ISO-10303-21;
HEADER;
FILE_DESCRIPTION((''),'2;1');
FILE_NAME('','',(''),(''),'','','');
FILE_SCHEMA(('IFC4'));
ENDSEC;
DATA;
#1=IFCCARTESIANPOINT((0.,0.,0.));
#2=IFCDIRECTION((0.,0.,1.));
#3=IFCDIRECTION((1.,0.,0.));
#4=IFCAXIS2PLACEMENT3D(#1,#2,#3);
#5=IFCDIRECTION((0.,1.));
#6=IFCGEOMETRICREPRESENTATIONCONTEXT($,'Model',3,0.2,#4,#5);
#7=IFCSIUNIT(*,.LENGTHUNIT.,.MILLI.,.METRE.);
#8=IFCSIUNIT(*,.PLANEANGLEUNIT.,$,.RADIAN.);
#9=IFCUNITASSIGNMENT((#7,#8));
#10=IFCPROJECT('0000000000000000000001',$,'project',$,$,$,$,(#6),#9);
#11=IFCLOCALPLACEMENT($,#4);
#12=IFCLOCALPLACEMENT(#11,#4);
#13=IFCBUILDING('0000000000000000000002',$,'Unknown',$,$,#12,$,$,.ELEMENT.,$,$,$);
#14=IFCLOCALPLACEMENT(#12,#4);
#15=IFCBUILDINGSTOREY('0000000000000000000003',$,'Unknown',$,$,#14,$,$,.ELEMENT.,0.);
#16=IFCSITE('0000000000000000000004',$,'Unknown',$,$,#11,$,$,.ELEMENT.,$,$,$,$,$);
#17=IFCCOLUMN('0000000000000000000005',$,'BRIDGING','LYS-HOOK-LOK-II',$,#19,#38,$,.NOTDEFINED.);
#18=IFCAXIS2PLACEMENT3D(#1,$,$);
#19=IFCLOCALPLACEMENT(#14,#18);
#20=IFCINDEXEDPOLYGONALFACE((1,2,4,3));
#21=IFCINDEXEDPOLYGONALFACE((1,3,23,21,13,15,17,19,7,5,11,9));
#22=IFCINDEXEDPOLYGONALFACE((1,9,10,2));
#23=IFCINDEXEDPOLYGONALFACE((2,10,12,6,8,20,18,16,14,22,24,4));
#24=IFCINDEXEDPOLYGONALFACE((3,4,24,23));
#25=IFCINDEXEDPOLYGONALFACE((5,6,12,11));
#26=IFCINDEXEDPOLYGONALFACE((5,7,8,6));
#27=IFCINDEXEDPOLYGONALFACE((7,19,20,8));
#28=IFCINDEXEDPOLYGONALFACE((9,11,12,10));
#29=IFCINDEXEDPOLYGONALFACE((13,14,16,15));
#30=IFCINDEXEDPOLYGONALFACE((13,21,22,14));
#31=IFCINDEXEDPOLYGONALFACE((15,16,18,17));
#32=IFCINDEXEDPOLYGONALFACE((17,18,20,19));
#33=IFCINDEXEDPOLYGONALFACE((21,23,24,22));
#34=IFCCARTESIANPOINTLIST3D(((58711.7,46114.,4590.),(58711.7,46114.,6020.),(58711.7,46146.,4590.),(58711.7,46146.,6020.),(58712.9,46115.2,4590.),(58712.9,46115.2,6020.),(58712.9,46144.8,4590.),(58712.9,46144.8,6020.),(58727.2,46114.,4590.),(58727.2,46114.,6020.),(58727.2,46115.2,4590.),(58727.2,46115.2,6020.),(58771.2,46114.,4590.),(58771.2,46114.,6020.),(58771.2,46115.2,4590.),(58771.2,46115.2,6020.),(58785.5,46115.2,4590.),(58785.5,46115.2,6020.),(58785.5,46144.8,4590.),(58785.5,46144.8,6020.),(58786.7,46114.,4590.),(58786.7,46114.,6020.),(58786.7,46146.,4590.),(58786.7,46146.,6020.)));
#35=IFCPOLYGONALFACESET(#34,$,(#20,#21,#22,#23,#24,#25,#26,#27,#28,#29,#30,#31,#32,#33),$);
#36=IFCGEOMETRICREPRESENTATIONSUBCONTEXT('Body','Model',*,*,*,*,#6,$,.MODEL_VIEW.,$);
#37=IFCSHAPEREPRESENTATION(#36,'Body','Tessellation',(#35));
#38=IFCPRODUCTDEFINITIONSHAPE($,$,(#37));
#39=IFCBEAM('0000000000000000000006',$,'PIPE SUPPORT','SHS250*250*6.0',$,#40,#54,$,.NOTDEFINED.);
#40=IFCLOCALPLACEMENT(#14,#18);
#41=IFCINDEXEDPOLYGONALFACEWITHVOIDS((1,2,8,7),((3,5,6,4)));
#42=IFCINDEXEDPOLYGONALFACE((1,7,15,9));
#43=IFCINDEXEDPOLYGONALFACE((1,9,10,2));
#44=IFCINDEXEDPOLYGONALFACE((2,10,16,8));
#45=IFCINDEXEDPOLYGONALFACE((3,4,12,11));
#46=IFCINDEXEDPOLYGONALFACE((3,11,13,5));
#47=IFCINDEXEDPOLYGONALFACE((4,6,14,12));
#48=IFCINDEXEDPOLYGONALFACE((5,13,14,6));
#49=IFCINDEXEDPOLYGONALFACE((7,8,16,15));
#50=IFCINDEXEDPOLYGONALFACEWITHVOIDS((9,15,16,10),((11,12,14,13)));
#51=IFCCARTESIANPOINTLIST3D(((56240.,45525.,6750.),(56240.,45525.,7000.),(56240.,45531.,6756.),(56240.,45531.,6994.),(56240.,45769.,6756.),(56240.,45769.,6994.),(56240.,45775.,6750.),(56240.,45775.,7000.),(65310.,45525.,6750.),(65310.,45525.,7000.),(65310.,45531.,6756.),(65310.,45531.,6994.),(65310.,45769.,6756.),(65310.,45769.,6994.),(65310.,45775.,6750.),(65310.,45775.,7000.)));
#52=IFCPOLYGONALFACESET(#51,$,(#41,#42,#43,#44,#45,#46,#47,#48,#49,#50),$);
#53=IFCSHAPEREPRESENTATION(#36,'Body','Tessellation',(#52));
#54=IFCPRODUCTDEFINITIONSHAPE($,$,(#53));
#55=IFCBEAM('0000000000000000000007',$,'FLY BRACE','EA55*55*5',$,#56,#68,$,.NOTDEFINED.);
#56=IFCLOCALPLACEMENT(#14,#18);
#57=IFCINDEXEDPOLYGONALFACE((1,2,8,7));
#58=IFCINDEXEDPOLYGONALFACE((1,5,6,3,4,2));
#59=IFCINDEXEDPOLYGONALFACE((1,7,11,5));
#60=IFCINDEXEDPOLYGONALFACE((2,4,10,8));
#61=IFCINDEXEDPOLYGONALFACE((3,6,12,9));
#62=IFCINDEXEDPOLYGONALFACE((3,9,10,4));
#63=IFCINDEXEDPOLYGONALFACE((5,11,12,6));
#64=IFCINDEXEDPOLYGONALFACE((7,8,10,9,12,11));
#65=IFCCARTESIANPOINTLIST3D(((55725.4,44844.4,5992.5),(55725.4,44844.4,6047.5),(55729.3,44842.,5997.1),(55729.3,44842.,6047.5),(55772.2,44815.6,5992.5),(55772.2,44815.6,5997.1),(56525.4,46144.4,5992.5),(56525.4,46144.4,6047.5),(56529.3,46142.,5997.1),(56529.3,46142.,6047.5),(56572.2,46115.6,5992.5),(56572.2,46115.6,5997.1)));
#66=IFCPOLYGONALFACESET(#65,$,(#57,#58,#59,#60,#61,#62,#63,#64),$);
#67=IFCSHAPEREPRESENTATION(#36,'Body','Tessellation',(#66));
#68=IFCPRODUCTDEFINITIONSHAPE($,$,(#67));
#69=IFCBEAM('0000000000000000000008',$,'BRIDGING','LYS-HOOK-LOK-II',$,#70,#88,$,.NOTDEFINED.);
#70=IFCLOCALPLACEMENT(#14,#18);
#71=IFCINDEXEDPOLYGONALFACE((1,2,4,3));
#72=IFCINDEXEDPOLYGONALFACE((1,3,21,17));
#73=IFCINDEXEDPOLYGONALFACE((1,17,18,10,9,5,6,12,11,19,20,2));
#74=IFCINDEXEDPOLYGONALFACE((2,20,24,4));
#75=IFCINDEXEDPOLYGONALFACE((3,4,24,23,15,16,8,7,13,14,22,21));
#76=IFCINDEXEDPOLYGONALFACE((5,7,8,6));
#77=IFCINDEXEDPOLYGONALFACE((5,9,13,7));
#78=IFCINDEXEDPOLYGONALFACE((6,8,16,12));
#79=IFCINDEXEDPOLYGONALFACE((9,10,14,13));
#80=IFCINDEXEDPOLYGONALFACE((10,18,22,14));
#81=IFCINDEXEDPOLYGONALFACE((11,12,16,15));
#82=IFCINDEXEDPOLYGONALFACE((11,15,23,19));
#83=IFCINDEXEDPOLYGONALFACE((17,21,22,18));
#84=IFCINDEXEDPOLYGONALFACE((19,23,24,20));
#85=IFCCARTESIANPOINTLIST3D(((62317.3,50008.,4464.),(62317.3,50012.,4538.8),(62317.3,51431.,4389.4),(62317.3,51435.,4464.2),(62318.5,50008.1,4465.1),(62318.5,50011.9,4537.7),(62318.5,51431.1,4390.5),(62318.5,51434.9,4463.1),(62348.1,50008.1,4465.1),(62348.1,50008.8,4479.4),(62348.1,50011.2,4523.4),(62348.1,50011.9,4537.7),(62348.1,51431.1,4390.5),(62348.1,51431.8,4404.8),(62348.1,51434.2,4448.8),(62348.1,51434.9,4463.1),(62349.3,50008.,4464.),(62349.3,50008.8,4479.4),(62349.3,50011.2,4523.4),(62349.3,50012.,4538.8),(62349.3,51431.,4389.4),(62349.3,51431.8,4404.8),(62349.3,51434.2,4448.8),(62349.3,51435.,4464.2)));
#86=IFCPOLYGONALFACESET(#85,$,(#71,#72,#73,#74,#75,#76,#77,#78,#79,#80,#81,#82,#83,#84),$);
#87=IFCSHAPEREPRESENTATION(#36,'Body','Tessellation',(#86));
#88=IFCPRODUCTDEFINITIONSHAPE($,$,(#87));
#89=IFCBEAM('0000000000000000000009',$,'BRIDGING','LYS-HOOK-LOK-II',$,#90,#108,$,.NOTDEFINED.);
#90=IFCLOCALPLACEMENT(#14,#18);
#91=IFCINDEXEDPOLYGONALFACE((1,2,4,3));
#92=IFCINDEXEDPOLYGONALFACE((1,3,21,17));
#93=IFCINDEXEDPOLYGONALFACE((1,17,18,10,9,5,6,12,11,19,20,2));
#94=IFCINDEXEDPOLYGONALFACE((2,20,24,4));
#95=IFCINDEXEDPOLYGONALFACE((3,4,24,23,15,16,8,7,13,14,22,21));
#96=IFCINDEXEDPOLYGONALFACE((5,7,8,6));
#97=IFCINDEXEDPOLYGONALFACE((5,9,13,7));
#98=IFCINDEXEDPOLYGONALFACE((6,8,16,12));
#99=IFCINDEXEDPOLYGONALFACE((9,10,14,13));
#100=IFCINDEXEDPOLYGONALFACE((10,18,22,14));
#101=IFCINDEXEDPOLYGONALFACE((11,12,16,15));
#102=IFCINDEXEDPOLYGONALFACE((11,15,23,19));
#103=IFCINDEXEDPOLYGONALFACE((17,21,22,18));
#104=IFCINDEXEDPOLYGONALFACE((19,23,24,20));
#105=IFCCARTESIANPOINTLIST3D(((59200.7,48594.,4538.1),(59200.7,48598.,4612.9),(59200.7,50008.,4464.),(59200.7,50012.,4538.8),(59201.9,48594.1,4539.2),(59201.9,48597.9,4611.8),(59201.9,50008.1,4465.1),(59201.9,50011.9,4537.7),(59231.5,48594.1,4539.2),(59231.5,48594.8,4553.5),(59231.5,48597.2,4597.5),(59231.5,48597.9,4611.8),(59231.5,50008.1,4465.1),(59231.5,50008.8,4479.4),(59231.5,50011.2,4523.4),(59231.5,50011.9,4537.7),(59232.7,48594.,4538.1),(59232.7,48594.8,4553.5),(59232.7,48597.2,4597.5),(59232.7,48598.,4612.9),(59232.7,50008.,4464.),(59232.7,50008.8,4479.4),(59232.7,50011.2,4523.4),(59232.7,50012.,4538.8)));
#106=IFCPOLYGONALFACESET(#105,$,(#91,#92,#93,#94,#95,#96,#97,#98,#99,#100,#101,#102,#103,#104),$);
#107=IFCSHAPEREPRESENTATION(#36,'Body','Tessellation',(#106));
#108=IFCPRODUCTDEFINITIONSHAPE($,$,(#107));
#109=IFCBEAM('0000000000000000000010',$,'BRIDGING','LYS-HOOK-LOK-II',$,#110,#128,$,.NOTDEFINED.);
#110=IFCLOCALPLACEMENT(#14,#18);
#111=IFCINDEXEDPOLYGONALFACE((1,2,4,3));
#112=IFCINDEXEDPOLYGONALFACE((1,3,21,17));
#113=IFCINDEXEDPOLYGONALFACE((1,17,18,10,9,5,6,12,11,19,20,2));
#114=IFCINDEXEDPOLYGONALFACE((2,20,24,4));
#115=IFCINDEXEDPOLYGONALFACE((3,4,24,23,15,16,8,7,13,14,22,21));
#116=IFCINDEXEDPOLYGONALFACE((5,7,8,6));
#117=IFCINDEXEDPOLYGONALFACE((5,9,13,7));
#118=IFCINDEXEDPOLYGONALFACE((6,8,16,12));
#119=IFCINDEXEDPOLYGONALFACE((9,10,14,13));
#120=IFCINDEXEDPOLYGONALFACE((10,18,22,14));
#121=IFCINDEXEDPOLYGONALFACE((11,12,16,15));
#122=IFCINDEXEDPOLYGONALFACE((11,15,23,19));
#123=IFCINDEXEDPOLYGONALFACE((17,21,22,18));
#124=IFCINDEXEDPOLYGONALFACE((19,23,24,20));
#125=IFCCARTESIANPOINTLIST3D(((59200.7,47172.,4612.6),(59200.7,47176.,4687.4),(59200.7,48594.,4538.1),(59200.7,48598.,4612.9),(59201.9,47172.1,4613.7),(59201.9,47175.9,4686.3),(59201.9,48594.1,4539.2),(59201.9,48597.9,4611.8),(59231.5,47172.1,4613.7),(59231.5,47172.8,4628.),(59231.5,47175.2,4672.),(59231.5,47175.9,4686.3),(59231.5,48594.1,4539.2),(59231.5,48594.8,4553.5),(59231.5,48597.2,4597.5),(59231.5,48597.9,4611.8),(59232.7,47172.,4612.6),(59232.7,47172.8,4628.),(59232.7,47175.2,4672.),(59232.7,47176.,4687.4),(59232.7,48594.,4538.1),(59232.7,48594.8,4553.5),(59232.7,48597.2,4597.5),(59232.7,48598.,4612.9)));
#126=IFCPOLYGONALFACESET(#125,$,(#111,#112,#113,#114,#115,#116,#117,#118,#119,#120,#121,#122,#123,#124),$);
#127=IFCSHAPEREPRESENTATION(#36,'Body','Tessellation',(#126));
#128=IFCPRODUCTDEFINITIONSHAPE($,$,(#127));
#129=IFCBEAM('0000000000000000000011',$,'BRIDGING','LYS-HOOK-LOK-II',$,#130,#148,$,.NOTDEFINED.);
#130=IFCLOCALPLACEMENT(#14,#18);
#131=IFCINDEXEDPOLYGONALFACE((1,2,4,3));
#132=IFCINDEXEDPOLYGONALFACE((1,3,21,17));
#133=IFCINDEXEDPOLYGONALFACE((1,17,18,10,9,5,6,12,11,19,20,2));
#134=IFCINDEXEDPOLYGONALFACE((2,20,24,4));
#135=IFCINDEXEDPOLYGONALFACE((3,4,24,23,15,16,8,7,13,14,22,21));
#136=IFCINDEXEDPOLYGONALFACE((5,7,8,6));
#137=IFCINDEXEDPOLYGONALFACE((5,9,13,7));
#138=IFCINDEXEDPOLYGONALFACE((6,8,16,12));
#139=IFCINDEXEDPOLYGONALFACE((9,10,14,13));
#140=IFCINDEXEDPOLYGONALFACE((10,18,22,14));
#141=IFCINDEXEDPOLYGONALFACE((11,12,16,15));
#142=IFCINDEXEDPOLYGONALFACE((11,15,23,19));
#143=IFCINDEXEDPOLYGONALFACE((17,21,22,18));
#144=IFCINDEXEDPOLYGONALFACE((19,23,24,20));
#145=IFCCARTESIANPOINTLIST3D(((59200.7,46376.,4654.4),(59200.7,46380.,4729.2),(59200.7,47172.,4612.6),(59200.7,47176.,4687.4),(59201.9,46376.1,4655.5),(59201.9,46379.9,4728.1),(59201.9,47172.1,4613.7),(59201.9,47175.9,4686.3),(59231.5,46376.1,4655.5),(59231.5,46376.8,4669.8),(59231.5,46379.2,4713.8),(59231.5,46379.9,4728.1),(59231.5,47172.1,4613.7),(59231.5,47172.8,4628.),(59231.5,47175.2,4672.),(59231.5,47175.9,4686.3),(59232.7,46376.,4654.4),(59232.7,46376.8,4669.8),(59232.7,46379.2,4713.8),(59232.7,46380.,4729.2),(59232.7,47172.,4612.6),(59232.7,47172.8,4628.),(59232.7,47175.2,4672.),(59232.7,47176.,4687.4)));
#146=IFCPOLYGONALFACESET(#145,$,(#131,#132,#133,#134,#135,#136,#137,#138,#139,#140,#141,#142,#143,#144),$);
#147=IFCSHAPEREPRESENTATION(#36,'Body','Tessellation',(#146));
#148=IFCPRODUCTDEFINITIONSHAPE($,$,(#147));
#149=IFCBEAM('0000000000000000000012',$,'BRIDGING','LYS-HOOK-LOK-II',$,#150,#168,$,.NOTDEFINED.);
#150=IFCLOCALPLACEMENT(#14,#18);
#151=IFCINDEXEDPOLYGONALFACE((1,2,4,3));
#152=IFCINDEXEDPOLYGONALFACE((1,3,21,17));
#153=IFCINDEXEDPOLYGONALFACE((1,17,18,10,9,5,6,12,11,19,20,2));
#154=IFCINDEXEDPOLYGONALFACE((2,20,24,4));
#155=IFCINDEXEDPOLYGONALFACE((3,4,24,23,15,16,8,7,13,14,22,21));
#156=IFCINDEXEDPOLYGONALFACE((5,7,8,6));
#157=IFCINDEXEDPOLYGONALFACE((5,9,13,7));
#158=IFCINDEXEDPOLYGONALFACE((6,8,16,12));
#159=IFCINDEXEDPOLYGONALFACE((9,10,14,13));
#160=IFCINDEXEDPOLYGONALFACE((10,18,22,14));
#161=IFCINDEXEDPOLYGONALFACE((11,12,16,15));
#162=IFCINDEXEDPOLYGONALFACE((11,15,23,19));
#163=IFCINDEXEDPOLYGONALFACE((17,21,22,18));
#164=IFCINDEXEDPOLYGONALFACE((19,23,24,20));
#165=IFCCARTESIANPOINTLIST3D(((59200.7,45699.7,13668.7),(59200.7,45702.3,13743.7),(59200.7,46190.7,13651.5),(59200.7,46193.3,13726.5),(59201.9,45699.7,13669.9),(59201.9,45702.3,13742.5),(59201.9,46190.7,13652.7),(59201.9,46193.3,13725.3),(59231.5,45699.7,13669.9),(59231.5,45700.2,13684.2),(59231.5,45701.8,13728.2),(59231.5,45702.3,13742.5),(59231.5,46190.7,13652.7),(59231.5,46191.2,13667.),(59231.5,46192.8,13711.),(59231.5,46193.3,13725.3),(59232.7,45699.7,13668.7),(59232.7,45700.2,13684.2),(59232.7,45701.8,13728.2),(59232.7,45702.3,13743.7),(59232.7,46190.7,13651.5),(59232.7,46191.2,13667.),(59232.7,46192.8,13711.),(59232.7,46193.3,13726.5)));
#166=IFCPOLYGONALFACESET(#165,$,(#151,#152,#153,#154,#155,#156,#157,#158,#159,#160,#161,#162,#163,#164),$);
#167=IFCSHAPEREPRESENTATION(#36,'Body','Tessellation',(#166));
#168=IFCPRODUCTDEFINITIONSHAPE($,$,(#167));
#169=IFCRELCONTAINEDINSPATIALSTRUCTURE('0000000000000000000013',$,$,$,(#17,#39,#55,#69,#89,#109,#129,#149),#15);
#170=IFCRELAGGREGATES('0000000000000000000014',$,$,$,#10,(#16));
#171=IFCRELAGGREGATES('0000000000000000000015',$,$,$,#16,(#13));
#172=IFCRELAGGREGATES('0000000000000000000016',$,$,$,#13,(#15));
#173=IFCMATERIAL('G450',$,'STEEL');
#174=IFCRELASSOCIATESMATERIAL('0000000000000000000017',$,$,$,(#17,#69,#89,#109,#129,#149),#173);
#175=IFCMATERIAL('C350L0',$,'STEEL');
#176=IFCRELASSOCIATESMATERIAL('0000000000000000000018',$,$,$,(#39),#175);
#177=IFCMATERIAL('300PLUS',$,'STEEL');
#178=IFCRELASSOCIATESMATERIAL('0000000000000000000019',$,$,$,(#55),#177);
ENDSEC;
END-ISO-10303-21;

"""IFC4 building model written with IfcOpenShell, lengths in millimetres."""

from ifc_helpers import new_model, si_unit, direction, frame, origin_with_axes, place, context, subcontext, project, spatial, line, indexed_curve, outline, extrude, material, element, save


model = new_model("IFC4")

# Units and contexts
model_context = context("Model", 3, precision=0.2, world=origin_with_axes(), true_north=direction((0.0, 1.0)))
body_context = subcontext(model_context, "Body", "Model", "MODEL_VIEW")
ifc_project = project(units=[si_unit("LENGTHUNIT", "METRE", prefix="MILLI"), si_unit("PLANEANGLEUNIT", "RADIAN")], contexts=[model_context])

# Site, building, storey
site_placement = place(None, origin_with_axes())
site = spatial("IfcSite", under=ifc_project, at=site_placement, Name="Unknown", CompositionType="ELEMENT")
building_placement = place(site_placement, origin_with_axes())
building = spatial("IfcBuilding", under=site, at=building_placement, Name="Unknown", CompositionType="ELEMENT")
storey_placement = place(building_placement, origin_with_axes())
storey = spatial("IfcBuildingStorey", under=building, at=storey_placement, Name="Unknown", CompositionType="ELEMENT", Elevation=0.0)

# Column
ifc_material_1 = material(Name="G450", Category="STEEL")
for number, where, z_axis, x_axis, name in (
    (1, (58749.2, 46130.0, 4590.0), (0.0, -1.0, 0.0), (0.0, 0.0, 1.0), "BRIDGING"),
):
    element("IfcColumn", number, at=place(storey_placement, frame(where, z_axis=z_axis, x_axis=x_axis)), inside=storey, material=ifc_material_1, Name=name, Description="LYS-HOOK-LOK-II", PredefinedType="NOTDEFINED", context=body_context, shape_type="SolidModel", body=[
        extrude(outline(indexed_curve([(16.0, -37.5), (16.0, -22.0), (14.8, -22.0), (14.8, -36.3), (-14.8, -36.3), (-14.8, 36.3), (14.8, 36.3), (14.8, 22.0), (16.0, 22.0), (16.0, 37.5), (-16.0, 37.5), (-16.0, -37.5)], segments=[line(1, 2, 3, 4, 5, 6, 7, 8, 9, 10, 11, 12, 1)])), frame((0.0, 0.0, 0.0), z_axis=(-1.0, 0.0, 0.0), x_axis=(0.0, 0.0, 1.0)), (0.0, 0.0, -1.0), 1430.0),
    ])

# Beams
ifc_material_2 = material(Name="C350L0", Category="STEEL")
beam_1_placement = place(storey_placement, frame((56240.0, 45650.0, 6875.0), z_axis=(0.0, 0.0, 1.0), x_axis=(1.0, 0.0, 0.0)))
element("IfcBeam", 2, at=beam_1_placement, inside=storey, material=ifc_material_2, Name="PIPE SUPPORT", Description="SHS250*250*6.0", PredefinedType="NOTDEFINED", context=body_context, shape_type="SolidModel", body=[
    extrude(outline(indexed_curve([(-125.0, -125.0), (125.0, -125.0), (125.0, 125.0), (-125.0, 125.0)], segments=[line(1, 2, 3, 4, 1)]), holes=[indexed_curve([(-119.0, -119.0), (-119.0, 119.0), (119.0, 119.0), (119.0, -119.0)], segments=[line(1, 2, 3, 4, 1)])]), frame((0.0, 0.0, 0.0), z_axis=(-1.0, 0.0, 0.0), x_axis=(0.0, 0.0, 1.0)), (0.0, 0.0, -1.0), 9070.0),
])
ifc_material_3 = material(Name="300PLUS", Category="STEEL")
beam_2_placement = place(storey_placement, frame((56548.8, 46130.0, 6020.0), z_axis=(0.0, 0.0, 1.0), x_axis=(-0.524097, -0.851658, 0.0)))
element("IfcBeam", 3, at=beam_2_placement, inside=storey, material=ifc_material_3, Name="FLY BRACE", Description="EA55*55*5", PredefinedType="NOTDEFINED", context=body_context, shape_type="SolidModel", body=[
    extrude(outline(indexed_curve([(-27.5, -27.5), (27.5, -27.5), (27.5, -22.9), (-22.9, -22.9), (-22.9, 27.5), (-27.5, 27.5)], segments=[line(1, 2, 3, 4, 5, 6, 1)])), frame((0.0, 0.0, 0.0), z_axis=(-1.0, 0.0, 0.0), x_axis=(0.0, 0.0, 1.0)), (0.0, 0.0, -1.0), 1526.4),
])
beam_3_placement = place(storey_placement, frame((62333.3, 50010.0, 4501.4), z_axis=(1.0, 0.0, 0.0), x_axis=(0.0, 0.998629, -0.052353)))
element("IfcBeam", 4, at=beam_3_placement, inside=storey, material=ifc_material_1, Name="BRIDGING", Description="LYS-HOOK-LOK-II", PredefinedType="NOTDEFINED", context=body_context, shape_type="SolidModel", body=[
    extrude(outline(indexed_curve([(16.0, -37.5), (16.0, -22.0), (14.8, -22.0), (14.8, -36.3), (-14.8, -36.3), (-14.8, 36.3), (14.8, 36.3), (14.8, 22.0), (16.0, 22.0), (16.0, 37.5), (-16.0, 37.5), (-16.0, -37.5)], segments=[line(1, 2, 3, 4, 5, 6, 7, 8, 9, 10, 11, 12, 1)])), frame((0.0, 0.0, 0.0), z_axis=(-1.0, 0.0, 0.0), x_axis=(0.0, 0.0, 1.0)), (0.0, 0.0, -1.0), 1425.0),
])
beam_4_placement = place(storey_placement, frame((59216.7, 48596.0, 4575.5), z_axis=(1.0, 0.0, 0.0), x_axis=(0.0, 0.99863, -0.052333)))
element("IfcBeam", 5, at=beam_4_placement, inside=storey, material=ifc_material_1, Name="BRIDGING", Description="LYS-HOOK-LOK-II", PredefinedType="NOTDEFINED", context=body_context, shape_type="SolidModel", body=[
    extrude(outline(indexed_curve([(16.0, -37.5), (16.0, -22.0), (14.8, -22.0), (14.8, -36.3), (-14.8, -36.3), (-14.8, 36.3), (14.8, 36.3), (14.8, 22.0), (16.0, 22.0), (16.0, 37.5), (-16.0, 37.5), (-16.0, -37.5)], segments=[line(1, 2, 3, 4, 5, 6, 7, 8, 9, 10, 11, 12, 1)])), frame((0.0, 0.0, 0.0), z_axis=(-1.0, 0.0, 0.0), x_axis=(0.0, 0.0, 1.0)), (0.0, 0.0, -1.0), 1415.9),
])
beam_5_placement = place(storey_placement, frame((59216.7, 47174.0, 4650.0), z_axis=(1.0, 0.0, 0.0), x_axis=(0.0, 0.99863, -0.052319)))
element("IfcBeam", 6, at=beam_5_placement, inside=storey, material=ifc_material_1, Name="BRIDGING", Description="LYS-HOOK-LOK-II", PredefinedType="NOTDEFINED", context=body_context, shape_type="SolidModel", body=[
    extrude(outline(indexed_curve([(16.0, -37.5), (16.0, -22.0), (14.8, -22.0), (14.8, -36.3), (-14.8, -36.3), (-14.8, 36.3), (14.8, 36.3), (14.8, 22.0), (16.0, 22.0), (16.0, 37.5), (-16.0, 37.5), (-16.0, -37.5)], segments=[line(1, 2, 3, 4, 5, 6, 7, 8, 9, 10, 11, 12, 1)])), frame((0.0, 0.0, 0.0), z_axis=(-1.0, 0.0, 0.0), x_axis=(0.0, 0.0, 1.0)), (0.0, 0.0, -1.0), 1424.0),
])
beam_6_placement = place(storey_placement, frame((59216.7, 46378.0, 4691.8), z_axis=(1.0, 0.0, 0.0), x_axis=(0.0, 0.998624, -0.05244)))
element("IfcBeam", 7, at=beam_6_placement, inside=storey, material=ifc_material_1, Name="BRIDGING", Description="LYS-HOOK-LOK-II", PredefinedType="NOTDEFINED", context=body_context, shape_type="SolidModel", body=[
    extrude(outline(indexed_curve([(16.0, -37.5), (16.0, -22.0), (14.8, -22.0), (14.8, -36.3), (-14.8, -36.3), (-14.8, 36.3), (14.8, 36.3), (14.8, 22.0), (16.0, 22.0), (16.0, 37.5), (-16.0, 37.5), (-16.0, -37.5)], segments=[line(1, 2, 3, 4, 5, 6, 7, 8, 9, 10, 11, 12, 1)])), frame((0.0, 0.0, 0.0), z_axis=(-1.0, 0.0, 0.0), x_axis=(0.0, 0.0, 1.0)), (0.0, 0.0, -1.0), 797.1),
])
beam_7_placement = place(storey_placement, frame((59216.7, 45701.0, 13706.2), z_axis=(1.0, 0.0, 0.0), x_axis=(0.0, 0.999387, -0.035009)))
element("IfcBeam", 8, at=beam_7_placement, inside=storey, material=ifc_material_1, Name="BRIDGING", Description="LYS-HOOK-LOK-II", PredefinedType="NOTDEFINED", context=body_context, shape_type="SolidModel", body=[
    extrude(outline(indexed_curve([(16.0, -37.5), (16.0, -22.0), (14.8, -22.0), (14.8, -36.3), (-14.8, -36.3), (-14.8, 36.3), (14.8, 36.3), (14.8, 22.0), (16.0, 22.0), (16.0, 37.5), (-16.0, 37.5), (-16.0, -37.5)], segments=[line(1, 2, 3, 4, 5, 6, 7, 8, 9, 10, 11, 12, 1)])), frame((0.0, 0.0, 0.0), z_axis=(-1.0, 0.0, 0.0), x_axis=(0.0, 0.0, 1.0)), (0.0, 0.0, -1.0), 491.3),
])

save(model, "model.ifc")
